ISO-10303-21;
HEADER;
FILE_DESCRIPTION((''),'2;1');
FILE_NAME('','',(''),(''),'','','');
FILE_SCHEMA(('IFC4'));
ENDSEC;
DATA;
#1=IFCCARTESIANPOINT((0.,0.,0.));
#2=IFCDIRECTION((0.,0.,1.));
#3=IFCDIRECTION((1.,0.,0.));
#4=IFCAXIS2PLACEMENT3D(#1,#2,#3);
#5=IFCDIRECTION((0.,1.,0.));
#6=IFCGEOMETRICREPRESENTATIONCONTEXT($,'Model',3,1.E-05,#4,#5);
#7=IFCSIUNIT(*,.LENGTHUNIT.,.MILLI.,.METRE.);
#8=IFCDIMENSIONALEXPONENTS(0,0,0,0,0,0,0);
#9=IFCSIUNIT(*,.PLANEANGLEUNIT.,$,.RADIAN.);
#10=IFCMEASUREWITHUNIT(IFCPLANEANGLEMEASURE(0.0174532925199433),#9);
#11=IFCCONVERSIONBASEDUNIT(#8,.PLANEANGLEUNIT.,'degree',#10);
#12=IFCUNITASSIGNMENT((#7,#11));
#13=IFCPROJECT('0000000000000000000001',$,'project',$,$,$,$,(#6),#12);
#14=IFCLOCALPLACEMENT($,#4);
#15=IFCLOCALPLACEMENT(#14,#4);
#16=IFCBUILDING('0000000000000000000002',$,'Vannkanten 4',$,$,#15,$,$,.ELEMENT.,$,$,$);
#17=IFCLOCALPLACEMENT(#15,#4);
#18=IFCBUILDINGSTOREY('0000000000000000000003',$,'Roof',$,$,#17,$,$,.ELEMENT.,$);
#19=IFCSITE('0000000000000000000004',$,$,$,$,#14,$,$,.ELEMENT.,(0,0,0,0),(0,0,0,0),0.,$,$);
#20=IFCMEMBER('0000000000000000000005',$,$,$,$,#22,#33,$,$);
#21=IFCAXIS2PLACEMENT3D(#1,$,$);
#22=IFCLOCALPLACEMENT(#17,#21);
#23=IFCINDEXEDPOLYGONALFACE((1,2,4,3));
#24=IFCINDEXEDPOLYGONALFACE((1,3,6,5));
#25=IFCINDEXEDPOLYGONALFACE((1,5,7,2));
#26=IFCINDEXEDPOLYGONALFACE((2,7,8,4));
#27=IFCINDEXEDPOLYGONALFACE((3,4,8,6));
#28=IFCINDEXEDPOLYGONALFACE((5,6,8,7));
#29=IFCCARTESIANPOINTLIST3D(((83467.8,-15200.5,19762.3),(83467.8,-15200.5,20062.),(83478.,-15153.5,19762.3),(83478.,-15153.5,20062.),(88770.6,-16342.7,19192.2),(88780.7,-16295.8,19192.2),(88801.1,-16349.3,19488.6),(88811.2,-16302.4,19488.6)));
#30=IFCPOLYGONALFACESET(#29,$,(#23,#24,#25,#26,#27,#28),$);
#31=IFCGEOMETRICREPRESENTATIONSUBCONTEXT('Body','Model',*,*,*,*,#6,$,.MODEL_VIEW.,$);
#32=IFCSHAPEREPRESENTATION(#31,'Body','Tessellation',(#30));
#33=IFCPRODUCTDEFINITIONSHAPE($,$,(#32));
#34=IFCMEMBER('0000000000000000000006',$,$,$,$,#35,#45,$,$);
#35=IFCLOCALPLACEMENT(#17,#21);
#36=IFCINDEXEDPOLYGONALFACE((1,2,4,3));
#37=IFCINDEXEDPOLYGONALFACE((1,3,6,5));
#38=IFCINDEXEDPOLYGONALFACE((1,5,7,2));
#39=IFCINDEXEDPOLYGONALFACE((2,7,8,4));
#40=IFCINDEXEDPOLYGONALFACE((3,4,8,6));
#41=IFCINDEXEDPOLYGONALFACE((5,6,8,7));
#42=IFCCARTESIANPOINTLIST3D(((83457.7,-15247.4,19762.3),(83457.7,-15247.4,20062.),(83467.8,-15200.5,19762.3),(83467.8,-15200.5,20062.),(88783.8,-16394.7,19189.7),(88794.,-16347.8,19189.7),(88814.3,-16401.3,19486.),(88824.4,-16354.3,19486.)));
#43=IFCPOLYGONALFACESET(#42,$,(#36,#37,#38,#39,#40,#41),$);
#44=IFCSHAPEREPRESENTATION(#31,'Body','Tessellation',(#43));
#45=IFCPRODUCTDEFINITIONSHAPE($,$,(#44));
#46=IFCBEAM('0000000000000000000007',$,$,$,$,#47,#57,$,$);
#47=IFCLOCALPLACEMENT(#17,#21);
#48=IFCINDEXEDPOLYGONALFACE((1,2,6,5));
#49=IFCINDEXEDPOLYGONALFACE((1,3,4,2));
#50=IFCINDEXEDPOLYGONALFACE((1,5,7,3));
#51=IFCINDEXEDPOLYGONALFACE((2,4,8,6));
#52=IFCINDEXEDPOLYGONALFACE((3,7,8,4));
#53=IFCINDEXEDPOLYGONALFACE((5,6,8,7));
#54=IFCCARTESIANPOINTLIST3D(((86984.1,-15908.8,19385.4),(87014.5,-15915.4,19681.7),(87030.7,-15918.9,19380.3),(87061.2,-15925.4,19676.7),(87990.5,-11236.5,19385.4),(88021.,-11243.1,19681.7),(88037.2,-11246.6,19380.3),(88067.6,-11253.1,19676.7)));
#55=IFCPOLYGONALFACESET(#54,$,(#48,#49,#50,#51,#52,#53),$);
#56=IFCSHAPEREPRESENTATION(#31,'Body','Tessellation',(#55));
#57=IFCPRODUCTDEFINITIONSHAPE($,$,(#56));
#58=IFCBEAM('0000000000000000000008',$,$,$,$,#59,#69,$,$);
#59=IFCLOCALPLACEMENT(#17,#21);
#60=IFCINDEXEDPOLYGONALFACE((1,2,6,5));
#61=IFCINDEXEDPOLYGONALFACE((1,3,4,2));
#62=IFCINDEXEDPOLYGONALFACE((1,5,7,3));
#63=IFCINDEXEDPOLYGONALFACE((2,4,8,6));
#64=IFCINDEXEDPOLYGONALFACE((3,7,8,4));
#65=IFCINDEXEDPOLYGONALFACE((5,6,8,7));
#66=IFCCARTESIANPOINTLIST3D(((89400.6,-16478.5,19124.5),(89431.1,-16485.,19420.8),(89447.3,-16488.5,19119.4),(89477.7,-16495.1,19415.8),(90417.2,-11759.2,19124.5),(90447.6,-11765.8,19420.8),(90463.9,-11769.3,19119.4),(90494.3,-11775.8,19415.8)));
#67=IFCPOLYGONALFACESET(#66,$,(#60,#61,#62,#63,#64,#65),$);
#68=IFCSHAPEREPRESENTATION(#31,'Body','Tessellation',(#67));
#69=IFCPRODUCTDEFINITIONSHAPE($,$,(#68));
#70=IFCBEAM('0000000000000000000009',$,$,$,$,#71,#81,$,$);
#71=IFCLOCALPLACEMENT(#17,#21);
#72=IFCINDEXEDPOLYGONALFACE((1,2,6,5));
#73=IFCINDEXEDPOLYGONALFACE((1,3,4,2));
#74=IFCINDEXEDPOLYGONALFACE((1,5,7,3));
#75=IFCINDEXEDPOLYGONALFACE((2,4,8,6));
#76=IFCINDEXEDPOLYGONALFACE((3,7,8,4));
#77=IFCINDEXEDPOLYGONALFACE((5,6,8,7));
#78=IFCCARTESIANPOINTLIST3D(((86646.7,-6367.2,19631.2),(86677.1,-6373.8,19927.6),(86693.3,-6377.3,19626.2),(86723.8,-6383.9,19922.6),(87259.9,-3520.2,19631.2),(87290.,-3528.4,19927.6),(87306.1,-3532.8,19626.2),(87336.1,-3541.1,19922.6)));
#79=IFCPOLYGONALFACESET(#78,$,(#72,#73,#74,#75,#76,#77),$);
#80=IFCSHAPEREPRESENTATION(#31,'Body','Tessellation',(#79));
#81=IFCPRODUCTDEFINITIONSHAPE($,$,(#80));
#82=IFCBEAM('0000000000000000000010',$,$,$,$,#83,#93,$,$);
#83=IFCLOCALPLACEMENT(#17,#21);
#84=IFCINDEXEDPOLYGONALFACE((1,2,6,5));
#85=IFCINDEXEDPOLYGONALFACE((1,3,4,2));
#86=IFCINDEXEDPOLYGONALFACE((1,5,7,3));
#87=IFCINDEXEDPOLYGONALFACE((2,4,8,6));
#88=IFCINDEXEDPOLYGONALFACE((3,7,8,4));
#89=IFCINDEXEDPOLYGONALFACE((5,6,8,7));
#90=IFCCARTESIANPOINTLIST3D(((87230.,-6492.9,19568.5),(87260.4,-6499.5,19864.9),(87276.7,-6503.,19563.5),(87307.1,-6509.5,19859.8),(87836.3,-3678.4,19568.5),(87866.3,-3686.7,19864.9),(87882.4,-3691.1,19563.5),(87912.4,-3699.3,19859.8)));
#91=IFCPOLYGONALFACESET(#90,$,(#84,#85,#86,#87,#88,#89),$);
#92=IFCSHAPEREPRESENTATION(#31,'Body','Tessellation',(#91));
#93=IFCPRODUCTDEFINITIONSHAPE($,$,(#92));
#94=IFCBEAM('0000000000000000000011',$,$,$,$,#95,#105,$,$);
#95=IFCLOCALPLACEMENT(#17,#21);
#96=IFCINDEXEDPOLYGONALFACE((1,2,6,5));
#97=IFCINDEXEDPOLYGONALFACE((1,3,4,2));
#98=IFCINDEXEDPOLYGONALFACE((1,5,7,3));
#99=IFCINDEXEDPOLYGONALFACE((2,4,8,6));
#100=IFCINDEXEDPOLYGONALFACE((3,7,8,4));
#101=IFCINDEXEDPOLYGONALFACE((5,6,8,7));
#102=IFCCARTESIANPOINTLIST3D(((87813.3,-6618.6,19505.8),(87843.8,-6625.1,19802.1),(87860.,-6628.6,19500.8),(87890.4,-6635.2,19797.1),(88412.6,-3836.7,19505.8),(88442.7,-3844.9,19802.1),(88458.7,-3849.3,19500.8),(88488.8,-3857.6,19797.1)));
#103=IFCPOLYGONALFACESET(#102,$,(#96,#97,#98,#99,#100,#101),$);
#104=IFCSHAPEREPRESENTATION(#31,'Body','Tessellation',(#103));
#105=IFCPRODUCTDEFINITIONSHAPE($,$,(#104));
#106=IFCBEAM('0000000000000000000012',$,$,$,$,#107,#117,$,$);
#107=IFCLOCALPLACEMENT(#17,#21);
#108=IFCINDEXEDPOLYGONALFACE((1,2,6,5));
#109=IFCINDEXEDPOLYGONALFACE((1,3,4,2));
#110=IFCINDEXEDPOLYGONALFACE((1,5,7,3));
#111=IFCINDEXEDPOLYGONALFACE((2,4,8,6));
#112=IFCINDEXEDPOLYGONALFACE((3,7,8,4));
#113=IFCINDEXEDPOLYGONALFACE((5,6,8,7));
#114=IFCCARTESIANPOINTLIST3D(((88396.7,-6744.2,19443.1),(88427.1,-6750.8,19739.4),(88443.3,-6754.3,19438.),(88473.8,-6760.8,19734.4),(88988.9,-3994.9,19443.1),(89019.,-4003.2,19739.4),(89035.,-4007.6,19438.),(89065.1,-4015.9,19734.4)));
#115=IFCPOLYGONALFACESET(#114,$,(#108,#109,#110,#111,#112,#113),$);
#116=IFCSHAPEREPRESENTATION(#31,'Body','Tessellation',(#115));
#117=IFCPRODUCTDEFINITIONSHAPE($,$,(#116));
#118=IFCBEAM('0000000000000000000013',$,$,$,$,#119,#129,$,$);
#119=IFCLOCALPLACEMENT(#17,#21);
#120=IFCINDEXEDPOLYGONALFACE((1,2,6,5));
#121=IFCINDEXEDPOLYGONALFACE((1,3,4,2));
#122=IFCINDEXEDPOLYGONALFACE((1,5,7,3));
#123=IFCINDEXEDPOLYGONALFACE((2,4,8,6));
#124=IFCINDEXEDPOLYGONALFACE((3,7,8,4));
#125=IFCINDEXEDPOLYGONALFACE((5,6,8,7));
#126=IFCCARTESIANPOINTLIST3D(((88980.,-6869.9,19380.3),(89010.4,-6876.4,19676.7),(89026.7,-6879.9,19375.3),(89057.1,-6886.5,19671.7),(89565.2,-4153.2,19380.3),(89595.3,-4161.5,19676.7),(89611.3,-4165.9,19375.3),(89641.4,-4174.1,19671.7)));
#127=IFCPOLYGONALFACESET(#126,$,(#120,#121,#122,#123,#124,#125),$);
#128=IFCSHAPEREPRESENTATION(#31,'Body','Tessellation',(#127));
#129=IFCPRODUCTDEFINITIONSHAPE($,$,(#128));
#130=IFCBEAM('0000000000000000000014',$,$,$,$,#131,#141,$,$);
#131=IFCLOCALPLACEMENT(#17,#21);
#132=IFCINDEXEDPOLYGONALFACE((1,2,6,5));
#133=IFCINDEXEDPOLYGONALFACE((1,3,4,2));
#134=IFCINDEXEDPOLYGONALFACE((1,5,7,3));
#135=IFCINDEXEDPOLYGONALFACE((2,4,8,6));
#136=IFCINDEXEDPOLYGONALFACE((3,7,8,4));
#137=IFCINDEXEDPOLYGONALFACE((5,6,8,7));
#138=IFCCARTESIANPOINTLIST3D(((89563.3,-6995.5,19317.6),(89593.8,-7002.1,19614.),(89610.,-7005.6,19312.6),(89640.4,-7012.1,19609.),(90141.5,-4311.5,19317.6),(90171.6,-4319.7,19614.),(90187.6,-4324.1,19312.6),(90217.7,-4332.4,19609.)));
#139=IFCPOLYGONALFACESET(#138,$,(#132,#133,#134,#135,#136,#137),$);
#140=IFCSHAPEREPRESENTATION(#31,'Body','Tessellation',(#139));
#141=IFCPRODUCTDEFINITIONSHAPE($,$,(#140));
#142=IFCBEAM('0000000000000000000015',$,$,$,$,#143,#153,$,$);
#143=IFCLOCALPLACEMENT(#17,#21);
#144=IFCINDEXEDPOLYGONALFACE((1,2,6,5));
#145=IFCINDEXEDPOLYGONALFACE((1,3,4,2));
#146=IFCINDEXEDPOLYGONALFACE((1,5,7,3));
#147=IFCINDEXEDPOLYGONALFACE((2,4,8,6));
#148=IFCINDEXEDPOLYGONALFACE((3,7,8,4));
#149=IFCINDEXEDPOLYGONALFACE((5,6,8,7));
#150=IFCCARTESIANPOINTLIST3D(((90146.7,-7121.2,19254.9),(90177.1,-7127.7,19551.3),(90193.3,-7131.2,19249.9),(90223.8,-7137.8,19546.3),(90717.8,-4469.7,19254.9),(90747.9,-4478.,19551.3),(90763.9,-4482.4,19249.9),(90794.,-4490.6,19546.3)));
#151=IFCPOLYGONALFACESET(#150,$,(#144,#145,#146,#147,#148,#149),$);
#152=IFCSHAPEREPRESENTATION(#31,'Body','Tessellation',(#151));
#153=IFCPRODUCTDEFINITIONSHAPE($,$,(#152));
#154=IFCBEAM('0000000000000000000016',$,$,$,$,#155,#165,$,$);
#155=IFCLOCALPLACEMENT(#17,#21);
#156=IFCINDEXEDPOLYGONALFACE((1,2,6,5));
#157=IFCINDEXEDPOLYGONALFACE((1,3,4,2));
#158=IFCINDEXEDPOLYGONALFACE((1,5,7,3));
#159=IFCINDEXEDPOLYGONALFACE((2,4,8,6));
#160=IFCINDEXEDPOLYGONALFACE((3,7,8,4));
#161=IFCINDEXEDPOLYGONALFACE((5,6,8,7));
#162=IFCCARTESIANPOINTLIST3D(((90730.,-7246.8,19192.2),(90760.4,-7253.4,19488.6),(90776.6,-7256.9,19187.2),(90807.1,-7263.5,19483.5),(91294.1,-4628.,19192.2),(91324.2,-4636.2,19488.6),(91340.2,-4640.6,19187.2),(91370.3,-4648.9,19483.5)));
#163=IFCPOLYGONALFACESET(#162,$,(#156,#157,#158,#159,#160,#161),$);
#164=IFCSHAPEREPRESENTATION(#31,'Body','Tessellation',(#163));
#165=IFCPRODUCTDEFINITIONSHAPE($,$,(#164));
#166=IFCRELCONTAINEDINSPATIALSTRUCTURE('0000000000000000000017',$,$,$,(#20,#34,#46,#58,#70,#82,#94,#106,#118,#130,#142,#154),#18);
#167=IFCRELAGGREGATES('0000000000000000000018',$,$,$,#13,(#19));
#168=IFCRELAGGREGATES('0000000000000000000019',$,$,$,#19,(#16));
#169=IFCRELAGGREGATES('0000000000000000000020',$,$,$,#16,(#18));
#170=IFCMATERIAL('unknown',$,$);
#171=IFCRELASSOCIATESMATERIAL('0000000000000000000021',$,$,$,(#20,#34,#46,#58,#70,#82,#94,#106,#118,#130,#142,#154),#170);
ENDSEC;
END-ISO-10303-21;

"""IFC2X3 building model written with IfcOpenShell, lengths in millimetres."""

from ifc_helpers import new_model, entity, si_unit, converted_unit, direction, frame, origin_with_axes, place, context, subcontext, project, spatial, polyline, segment, composite_curve, outline, extrude, clip, halfspace, material, element, save


model = new_model("IFC2X3")

# Units and contexts
model_context = context("Model", 3, precision=1e-05, world=origin_with_axes(), true_north=direction((0.0, 1.0, 0.0)))
body_context = subcontext(model_context, "Body", "Model", "MODEL_VIEW")
ifc_project = project(units=[si_unit("LENGTHUNIT", "METRE", prefix="MILLI"), converted_unit("PLANEANGLEUNIT", "degree", entity("IfcPlaneAngleMeasure", 0.0174532925199433), si_unit("PLANEANGLEUNIT", "RADIAN"), dimensions=[0, 0, 0, 0, 0, 0, 0])], contexts=[model_context])

# Site, building, storey
site_placement = place(None, origin_with_axes())
site = spatial("IfcSite", under=ifc_project, at=site_placement, CompositionType="ELEMENT", RefLatitude=(0, 0, 0, 0), RefLongitude=(0, 0, 0, 0), RefElevation=0.0)
building_placement = place(site_placement, origin_with_axes())
building = spatial("IfcBuilding", under=site, at=building_placement, Name="Vannkanten 4", CompositionType="ELEMENT")
storey_placement = place(building_placement, origin_with_axes())
storey = spatial("IfcBuildingStorey", under=building, at=storey_placement, Name="Roof", CompositionType="ELEMENT")

# Members
ifc_material = material(Name="unknown")
member_1_placement = place(storey_placement, frame((88790.9, -16322.6, 19340.4), z_axis=(-0.972221, 0.209428, 0.104528), x_axis=(-0.210582, -0.977576, 0.0)))
element("IfcMember", 1, at=member_1_placement, inside=storey, material=ifc_material, context=body_context, shape_type="Clipping", body=[
    clip(extrude(outline(composite_curve([segment(polyline([(-24.0, -149.0), (-24.0, 149.0), (24.0, 149.0), (24.0, -149.0), (-24.0, -149.0)]), True, "CONTINUOUS")], self_intersect=False)), frame((0.0, 0.0, 0.0), z_axis=(0.0, 0.0, 1.0), x_axis=(1.0, 0.0, 0.0)), (0.0, 0.0, 1.0), 8228.4), halfspace(frame((-24.0, -149.0, 5454.3), z_axis=(0.0, 0.104528, -0.994522), x_axis=(0.0, -0.994522, -0.104528)), True)),
])
member_2_placement = place(storey_placement, frame((88804.1, -16374.5, 19337.9), z_axis=(-0.972221, 0.209428, 0.104528), x_axis=(-0.210582, -0.977576, 0.0)))
element("IfcMember", 2, at=member_2_placement, inside=storey, material=ifc_material, context=body_context, shape_type="Clipping", body=[
    clip(extrude(outline(composite_curve([segment(polyline([(-24.0, -149.0), (-24.0, 149.0), (24.0, 149.0), (24.0, -149.0), (-24.0, -149.0)]), True, "CONTINUOUS")], self_intersect=False)), frame((0.0, 0.0, 0.0), z_axis=(0.0, 0.0, 1.0), x_axis=(1.0, 0.0, 0.0)), (0.0, 0.0, 1.0), 8264.4), halfspace(frame((-24.0, -149.0, 5478.3), z_axis=(0.0, 0.104528, -0.994522), x_axis=(0.0, -0.994522, -0.104528)), True)),
])

# Beams
beam_1_placement = place(storey_placement, frame((87022.6, -15917.1, 19531.0), z_axis=(0.210582, 0.977576, 0.0), x_axis=(-0.972221, 0.209428, 0.104528)))
element("IfcBeam", 3, at=beam_1_placement, inside=storey, material=ifc_material, context=body_context, shape_type="SweptSolid", body=[
    extrude(outline(composite_curve([segment(polyline([(-24.0, -149.0), (-24.0, 149.0), (24.0, 149.0), (24.0, -149.0), (-24.0, -149.0)]), True, "CONTINUOUS")], self_intersect=False)), frame((0.0, 0.0, 0.0), z_axis=(0.0, 0.0, 1.0), x_axis=(1.0, 0.0, 0.0)), (0.0, 0.0, 1.0), 4779.4),
])
beam_2_placement = place(storey_placement, frame((89439.2, -16486.8, 19270.1), z_axis=(0.210582, 0.977576, 0.0), x_axis=(-0.972221, 0.209428, 0.104528)))
element("IfcBeam", 4, at=beam_2_placement, inside=storey, material=ifc_material, context=body_context, shape_type="SweptSolid", body=[
    extrude(outline(composite_curve([segment(polyline([(-24.0, -149.0), (-24.0, 149.0), (24.0, 149.0), (24.0, -149.0), (-24.0, -149.0)]), True, "CONTINUOUS")], self_intersect=False)), frame((0.0, 0.0, 0.0), z_axis=(0.0, 0.0, 1.0), x_axis=(1.0, 0.0, 0.0)), (0.0, 0.0, 1.0), 4827.5),
])
beam_3_placement = place(storey_placement, frame((86685.2, -6375.5, 19776.9), z_axis=(0.210582, 0.977576, 0.0), x_axis=(-0.972221, 0.209428, 0.104528)))
element("IfcBeam", 5, at=beam_3_placement, inside=storey, material=ifc_material, context=body_context, shape_type="Clipping", body=[
    clip(extrude(outline(composite_curve([segment(polyline([(-24.0, -149.0), (-24.0, 149.0), (24.0, 149.0), (24.0, -149.0), (-24.0, -149.0)]), True, "CONTINUOUS")], self_intersect=False)), frame((0.0, 0.0, 0.0), z_axis=(0.0, 0.0, 1.0), x_axis=(1.0, 0.0, 0.0)), (0.0, 0.0, 1.0), 4368.6), halfspace(frame((-24.0, -149.0, 2909.7), z_axis=(0.055493, -0.005833, -0.998442), x_axis=(-0.998459, 0.0, -0.055494)), True)),
])
beam_4_placement = place(storey_placement, frame((87268.5, -6501.2, 19714.2), z_axis=(0.210582, 0.977576, 0.0), x_axis=(-0.972221, 0.209428, 0.104528)))
element("IfcBeam", 6, at=beam_4_placement, inside=storey, material=ifc_material, context=body_context, shape_type="Clipping", body=[
    clip(extrude(outline(composite_curve([segment(polyline([(-24.0, -149.0), (-24.0, 149.0), (24.0, 149.0), (24.0, -149.0), (-24.0, -149.0)]), True, "CONTINUOUS")], self_intersect=False)), frame((0.0, 0.0, 0.0), z_axis=(0.0, 0.0, 1.0), x_axis=(1.0, 0.0, 0.0)), (0.0, 0.0, 1.0), 4318.6), halfspace(frame((-24.0, -149.0, 2876.4), z_axis=(0.055493, -0.005833, -0.998442), x_axis=(-0.998459, 0.0, -0.055494)), True)),
])
beam_5_placement = place(storey_placement, frame((87851.9, -6626.9, 19651.4), z_axis=(0.210582, 0.977576, 0.0), x_axis=(-0.972221, 0.209428, 0.104528)))
element("IfcBeam", 7, at=beam_5_placement, inside=storey, material=ifc_material, context=body_context, shape_type="Clipping", body=[
    clip(extrude(outline(composite_curve([segment(polyline([(-24.0, -149.0), (-24.0, 149.0), (24.0, 149.0), (24.0, -149.0), (-24.0, -149.0)]), True, "CONTINUOUS")], self_intersect=False)), frame((0.0, 0.0, 0.0), z_axis=(0.0, 0.0, 1.0), x_axis=(1.0, 0.0, 0.0)), (0.0, 0.0, 1.0), 4268.5), halfspace(frame((-24.0, -149.0, 2843.0), z_axis=(0.055493, -0.005833, -0.998442), x_axis=(-0.998459, 0.0, -0.055494)), True)),
])
beam_6_placement = place(storey_placement, frame((88435.2, -6752.5, 19588.7), z_axis=(0.210582, 0.977576, 0.0), x_axis=(-0.972221, 0.209428, 0.104528)))
element("IfcBeam", 8, at=beam_6_placement, inside=storey, material=ifc_material, context=body_context, shape_type="Clipping", body=[
    clip(extrude(outline(composite_curve([segment(polyline([(-24.0, -149.0), (-24.0, 149.0), (24.0, 149.0), (24.0, -149.0), (-24.0, -149.0)]), True, "CONTINUOUS")], self_intersect=False)), frame((0.0, 0.0, 0.0), z_axis=(0.0, 0.0, 1.0), x_axis=(1.0, 0.0, 0.0)), (0.0, 0.0, 1.0), 4218.5), halfspace(frame((-24.0, -149.0, 2809.7), z_axis=(0.055493, -0.005833, -0.998442), x_axis=(-0.998459, 0.0, -0.055494)), True)),
])
beam_7_placement = place(storey_placement, frame((89018.5, -6878.2, 19526.0), z_axis=(0.210582, 0.977576, 0.0), x_axis=(-0.972221, 0.209428, 0.104528)))
element("IfcBeam", 9, at=beam_7_placement, inside=storey, material=ifc_material, context=body_context, shape_type="Clipping", body=[
    clip(extrude(outline(composite_curve([segment(polyline([(-24.0, -149.0), (-24.0, 149.0), (24.0, 149.0), (24.0, -149.0), (-24.0, -149.0)]), True, "CONTINUOUS")], self_intersect=False)), frame((0.0, 0.0, 0.0), z_axis=(0.0, 0.0, 1.0), x_axis=(1.0, 0.0, 0.0)), (0.0, 0.0, 1.0), 4168.5), halfspace(frame((-24.0, -149.0, 2776.3), z_axis=(0.055493, -0.005833, -0.998442), x_axis=(-0.998459, 0.0, -0.055494)), True)),
])
beam_8_placement = place(storey_placement, frame((89601.9, -7003.8, 19463.3), z_axis=(0.210582, 0.977576, 0.0), x_axis=(-0.972221, 0.209428, 0.104528)))
element("IfcBeam", 10, at=beam_8_placement, inside=storey, material=ifc_material, context=body_context, shape_type="Clipping", body=[
    clip(extrude(outline(composite_curve([segment(polyline([(-24.0, -149.0), (-24.0, 149.0), (24.0, 149.0), (24.0, -149.0), (-24.0, -149.0)]), True, "CONTINUOUS")], self_intersect=False)), frame((0.0, 0.0, 0.0), z_axis=(0.0, 0.0, 1.0), x_axis=(1.0, 0.0, 0.0)), (0.0, 0.0, 1.0), 4118.5), halfspace(frame((-24.0, -149.0, 2743.0), z_axis=(0.055493, -0.005833, -0.998442), x_axis=(-0.998459, 0.0, -0.055494)), True)),
])
beam_9_placement = place(storey_placement, frame((90185.2, -7129.5, 19400.6), z_axis=(0.210582, 0.977576, 0.0), x_axis=(-0.972221, 0.209428, 0.104528)))
element("IfcBeam", 11, at=beam_9_placement, inside=storey, material=ifc_material, context=body_context, shape_type="Clipping", body=[
    clip(extrude(outline(composite_curve([segment(polyline([(-24.0, -149.0), (-24.0, 149.0), (24.0, 149.0), (24.0, -149.0), (-24.0, -149.0)]), True, "CONTINUOUS")], self_intersect=False)), frame((0.0, 0.0, 0.0), z_axis=(0.0, 0.0, 1.0), x_axis=(1.0, 0.0, 0.0)), (0.0, 0.0, 1.0), 4068.4), halfspace(frame((-24.0, -149.0, 2709.6), z_axis=(0.055493, -0.005833, -0.998442), x_axis=(-0.998459, 0.0, -0.055494)), True)),
])
beam_10_placement = place(storey_placement, frame((90768.5, -7255.1, 19337.9), z_axis=(0.210582, 0.977576, 0.0), x_axis=(-0.972221, 0.209428, 0.104528)))
element("IfcBeam", 12, at=beam_10_placement, inside=storey, material=ifc_material, context=body_context, shape_type="Clipping", body=[
    clip(extrude(outline(composite_curve([segment(polyline([(-24.0, -149.0), (-24.0, 149.0), (24.0, 149.0), (24.0, -149.0), (-24.0, -149.0)]), True, "CONTINUOUS")], self_intersect=False)), frame((0.0, 0.0, 0.0), z_axis=(0.0, 0.0, 1.0), x_axis=(1.0, 0.0, 0.0)), (0.0, 0.0, 1.0), 4018.4), halfspace(frame((-24.0, -149.0, 2676.3), z_axis=(0.055493, -0.005833, -0.998442), x_axis=(-0.998459, 0.0, -0.055494)), True)),
])

save(model, "model.ifc")
